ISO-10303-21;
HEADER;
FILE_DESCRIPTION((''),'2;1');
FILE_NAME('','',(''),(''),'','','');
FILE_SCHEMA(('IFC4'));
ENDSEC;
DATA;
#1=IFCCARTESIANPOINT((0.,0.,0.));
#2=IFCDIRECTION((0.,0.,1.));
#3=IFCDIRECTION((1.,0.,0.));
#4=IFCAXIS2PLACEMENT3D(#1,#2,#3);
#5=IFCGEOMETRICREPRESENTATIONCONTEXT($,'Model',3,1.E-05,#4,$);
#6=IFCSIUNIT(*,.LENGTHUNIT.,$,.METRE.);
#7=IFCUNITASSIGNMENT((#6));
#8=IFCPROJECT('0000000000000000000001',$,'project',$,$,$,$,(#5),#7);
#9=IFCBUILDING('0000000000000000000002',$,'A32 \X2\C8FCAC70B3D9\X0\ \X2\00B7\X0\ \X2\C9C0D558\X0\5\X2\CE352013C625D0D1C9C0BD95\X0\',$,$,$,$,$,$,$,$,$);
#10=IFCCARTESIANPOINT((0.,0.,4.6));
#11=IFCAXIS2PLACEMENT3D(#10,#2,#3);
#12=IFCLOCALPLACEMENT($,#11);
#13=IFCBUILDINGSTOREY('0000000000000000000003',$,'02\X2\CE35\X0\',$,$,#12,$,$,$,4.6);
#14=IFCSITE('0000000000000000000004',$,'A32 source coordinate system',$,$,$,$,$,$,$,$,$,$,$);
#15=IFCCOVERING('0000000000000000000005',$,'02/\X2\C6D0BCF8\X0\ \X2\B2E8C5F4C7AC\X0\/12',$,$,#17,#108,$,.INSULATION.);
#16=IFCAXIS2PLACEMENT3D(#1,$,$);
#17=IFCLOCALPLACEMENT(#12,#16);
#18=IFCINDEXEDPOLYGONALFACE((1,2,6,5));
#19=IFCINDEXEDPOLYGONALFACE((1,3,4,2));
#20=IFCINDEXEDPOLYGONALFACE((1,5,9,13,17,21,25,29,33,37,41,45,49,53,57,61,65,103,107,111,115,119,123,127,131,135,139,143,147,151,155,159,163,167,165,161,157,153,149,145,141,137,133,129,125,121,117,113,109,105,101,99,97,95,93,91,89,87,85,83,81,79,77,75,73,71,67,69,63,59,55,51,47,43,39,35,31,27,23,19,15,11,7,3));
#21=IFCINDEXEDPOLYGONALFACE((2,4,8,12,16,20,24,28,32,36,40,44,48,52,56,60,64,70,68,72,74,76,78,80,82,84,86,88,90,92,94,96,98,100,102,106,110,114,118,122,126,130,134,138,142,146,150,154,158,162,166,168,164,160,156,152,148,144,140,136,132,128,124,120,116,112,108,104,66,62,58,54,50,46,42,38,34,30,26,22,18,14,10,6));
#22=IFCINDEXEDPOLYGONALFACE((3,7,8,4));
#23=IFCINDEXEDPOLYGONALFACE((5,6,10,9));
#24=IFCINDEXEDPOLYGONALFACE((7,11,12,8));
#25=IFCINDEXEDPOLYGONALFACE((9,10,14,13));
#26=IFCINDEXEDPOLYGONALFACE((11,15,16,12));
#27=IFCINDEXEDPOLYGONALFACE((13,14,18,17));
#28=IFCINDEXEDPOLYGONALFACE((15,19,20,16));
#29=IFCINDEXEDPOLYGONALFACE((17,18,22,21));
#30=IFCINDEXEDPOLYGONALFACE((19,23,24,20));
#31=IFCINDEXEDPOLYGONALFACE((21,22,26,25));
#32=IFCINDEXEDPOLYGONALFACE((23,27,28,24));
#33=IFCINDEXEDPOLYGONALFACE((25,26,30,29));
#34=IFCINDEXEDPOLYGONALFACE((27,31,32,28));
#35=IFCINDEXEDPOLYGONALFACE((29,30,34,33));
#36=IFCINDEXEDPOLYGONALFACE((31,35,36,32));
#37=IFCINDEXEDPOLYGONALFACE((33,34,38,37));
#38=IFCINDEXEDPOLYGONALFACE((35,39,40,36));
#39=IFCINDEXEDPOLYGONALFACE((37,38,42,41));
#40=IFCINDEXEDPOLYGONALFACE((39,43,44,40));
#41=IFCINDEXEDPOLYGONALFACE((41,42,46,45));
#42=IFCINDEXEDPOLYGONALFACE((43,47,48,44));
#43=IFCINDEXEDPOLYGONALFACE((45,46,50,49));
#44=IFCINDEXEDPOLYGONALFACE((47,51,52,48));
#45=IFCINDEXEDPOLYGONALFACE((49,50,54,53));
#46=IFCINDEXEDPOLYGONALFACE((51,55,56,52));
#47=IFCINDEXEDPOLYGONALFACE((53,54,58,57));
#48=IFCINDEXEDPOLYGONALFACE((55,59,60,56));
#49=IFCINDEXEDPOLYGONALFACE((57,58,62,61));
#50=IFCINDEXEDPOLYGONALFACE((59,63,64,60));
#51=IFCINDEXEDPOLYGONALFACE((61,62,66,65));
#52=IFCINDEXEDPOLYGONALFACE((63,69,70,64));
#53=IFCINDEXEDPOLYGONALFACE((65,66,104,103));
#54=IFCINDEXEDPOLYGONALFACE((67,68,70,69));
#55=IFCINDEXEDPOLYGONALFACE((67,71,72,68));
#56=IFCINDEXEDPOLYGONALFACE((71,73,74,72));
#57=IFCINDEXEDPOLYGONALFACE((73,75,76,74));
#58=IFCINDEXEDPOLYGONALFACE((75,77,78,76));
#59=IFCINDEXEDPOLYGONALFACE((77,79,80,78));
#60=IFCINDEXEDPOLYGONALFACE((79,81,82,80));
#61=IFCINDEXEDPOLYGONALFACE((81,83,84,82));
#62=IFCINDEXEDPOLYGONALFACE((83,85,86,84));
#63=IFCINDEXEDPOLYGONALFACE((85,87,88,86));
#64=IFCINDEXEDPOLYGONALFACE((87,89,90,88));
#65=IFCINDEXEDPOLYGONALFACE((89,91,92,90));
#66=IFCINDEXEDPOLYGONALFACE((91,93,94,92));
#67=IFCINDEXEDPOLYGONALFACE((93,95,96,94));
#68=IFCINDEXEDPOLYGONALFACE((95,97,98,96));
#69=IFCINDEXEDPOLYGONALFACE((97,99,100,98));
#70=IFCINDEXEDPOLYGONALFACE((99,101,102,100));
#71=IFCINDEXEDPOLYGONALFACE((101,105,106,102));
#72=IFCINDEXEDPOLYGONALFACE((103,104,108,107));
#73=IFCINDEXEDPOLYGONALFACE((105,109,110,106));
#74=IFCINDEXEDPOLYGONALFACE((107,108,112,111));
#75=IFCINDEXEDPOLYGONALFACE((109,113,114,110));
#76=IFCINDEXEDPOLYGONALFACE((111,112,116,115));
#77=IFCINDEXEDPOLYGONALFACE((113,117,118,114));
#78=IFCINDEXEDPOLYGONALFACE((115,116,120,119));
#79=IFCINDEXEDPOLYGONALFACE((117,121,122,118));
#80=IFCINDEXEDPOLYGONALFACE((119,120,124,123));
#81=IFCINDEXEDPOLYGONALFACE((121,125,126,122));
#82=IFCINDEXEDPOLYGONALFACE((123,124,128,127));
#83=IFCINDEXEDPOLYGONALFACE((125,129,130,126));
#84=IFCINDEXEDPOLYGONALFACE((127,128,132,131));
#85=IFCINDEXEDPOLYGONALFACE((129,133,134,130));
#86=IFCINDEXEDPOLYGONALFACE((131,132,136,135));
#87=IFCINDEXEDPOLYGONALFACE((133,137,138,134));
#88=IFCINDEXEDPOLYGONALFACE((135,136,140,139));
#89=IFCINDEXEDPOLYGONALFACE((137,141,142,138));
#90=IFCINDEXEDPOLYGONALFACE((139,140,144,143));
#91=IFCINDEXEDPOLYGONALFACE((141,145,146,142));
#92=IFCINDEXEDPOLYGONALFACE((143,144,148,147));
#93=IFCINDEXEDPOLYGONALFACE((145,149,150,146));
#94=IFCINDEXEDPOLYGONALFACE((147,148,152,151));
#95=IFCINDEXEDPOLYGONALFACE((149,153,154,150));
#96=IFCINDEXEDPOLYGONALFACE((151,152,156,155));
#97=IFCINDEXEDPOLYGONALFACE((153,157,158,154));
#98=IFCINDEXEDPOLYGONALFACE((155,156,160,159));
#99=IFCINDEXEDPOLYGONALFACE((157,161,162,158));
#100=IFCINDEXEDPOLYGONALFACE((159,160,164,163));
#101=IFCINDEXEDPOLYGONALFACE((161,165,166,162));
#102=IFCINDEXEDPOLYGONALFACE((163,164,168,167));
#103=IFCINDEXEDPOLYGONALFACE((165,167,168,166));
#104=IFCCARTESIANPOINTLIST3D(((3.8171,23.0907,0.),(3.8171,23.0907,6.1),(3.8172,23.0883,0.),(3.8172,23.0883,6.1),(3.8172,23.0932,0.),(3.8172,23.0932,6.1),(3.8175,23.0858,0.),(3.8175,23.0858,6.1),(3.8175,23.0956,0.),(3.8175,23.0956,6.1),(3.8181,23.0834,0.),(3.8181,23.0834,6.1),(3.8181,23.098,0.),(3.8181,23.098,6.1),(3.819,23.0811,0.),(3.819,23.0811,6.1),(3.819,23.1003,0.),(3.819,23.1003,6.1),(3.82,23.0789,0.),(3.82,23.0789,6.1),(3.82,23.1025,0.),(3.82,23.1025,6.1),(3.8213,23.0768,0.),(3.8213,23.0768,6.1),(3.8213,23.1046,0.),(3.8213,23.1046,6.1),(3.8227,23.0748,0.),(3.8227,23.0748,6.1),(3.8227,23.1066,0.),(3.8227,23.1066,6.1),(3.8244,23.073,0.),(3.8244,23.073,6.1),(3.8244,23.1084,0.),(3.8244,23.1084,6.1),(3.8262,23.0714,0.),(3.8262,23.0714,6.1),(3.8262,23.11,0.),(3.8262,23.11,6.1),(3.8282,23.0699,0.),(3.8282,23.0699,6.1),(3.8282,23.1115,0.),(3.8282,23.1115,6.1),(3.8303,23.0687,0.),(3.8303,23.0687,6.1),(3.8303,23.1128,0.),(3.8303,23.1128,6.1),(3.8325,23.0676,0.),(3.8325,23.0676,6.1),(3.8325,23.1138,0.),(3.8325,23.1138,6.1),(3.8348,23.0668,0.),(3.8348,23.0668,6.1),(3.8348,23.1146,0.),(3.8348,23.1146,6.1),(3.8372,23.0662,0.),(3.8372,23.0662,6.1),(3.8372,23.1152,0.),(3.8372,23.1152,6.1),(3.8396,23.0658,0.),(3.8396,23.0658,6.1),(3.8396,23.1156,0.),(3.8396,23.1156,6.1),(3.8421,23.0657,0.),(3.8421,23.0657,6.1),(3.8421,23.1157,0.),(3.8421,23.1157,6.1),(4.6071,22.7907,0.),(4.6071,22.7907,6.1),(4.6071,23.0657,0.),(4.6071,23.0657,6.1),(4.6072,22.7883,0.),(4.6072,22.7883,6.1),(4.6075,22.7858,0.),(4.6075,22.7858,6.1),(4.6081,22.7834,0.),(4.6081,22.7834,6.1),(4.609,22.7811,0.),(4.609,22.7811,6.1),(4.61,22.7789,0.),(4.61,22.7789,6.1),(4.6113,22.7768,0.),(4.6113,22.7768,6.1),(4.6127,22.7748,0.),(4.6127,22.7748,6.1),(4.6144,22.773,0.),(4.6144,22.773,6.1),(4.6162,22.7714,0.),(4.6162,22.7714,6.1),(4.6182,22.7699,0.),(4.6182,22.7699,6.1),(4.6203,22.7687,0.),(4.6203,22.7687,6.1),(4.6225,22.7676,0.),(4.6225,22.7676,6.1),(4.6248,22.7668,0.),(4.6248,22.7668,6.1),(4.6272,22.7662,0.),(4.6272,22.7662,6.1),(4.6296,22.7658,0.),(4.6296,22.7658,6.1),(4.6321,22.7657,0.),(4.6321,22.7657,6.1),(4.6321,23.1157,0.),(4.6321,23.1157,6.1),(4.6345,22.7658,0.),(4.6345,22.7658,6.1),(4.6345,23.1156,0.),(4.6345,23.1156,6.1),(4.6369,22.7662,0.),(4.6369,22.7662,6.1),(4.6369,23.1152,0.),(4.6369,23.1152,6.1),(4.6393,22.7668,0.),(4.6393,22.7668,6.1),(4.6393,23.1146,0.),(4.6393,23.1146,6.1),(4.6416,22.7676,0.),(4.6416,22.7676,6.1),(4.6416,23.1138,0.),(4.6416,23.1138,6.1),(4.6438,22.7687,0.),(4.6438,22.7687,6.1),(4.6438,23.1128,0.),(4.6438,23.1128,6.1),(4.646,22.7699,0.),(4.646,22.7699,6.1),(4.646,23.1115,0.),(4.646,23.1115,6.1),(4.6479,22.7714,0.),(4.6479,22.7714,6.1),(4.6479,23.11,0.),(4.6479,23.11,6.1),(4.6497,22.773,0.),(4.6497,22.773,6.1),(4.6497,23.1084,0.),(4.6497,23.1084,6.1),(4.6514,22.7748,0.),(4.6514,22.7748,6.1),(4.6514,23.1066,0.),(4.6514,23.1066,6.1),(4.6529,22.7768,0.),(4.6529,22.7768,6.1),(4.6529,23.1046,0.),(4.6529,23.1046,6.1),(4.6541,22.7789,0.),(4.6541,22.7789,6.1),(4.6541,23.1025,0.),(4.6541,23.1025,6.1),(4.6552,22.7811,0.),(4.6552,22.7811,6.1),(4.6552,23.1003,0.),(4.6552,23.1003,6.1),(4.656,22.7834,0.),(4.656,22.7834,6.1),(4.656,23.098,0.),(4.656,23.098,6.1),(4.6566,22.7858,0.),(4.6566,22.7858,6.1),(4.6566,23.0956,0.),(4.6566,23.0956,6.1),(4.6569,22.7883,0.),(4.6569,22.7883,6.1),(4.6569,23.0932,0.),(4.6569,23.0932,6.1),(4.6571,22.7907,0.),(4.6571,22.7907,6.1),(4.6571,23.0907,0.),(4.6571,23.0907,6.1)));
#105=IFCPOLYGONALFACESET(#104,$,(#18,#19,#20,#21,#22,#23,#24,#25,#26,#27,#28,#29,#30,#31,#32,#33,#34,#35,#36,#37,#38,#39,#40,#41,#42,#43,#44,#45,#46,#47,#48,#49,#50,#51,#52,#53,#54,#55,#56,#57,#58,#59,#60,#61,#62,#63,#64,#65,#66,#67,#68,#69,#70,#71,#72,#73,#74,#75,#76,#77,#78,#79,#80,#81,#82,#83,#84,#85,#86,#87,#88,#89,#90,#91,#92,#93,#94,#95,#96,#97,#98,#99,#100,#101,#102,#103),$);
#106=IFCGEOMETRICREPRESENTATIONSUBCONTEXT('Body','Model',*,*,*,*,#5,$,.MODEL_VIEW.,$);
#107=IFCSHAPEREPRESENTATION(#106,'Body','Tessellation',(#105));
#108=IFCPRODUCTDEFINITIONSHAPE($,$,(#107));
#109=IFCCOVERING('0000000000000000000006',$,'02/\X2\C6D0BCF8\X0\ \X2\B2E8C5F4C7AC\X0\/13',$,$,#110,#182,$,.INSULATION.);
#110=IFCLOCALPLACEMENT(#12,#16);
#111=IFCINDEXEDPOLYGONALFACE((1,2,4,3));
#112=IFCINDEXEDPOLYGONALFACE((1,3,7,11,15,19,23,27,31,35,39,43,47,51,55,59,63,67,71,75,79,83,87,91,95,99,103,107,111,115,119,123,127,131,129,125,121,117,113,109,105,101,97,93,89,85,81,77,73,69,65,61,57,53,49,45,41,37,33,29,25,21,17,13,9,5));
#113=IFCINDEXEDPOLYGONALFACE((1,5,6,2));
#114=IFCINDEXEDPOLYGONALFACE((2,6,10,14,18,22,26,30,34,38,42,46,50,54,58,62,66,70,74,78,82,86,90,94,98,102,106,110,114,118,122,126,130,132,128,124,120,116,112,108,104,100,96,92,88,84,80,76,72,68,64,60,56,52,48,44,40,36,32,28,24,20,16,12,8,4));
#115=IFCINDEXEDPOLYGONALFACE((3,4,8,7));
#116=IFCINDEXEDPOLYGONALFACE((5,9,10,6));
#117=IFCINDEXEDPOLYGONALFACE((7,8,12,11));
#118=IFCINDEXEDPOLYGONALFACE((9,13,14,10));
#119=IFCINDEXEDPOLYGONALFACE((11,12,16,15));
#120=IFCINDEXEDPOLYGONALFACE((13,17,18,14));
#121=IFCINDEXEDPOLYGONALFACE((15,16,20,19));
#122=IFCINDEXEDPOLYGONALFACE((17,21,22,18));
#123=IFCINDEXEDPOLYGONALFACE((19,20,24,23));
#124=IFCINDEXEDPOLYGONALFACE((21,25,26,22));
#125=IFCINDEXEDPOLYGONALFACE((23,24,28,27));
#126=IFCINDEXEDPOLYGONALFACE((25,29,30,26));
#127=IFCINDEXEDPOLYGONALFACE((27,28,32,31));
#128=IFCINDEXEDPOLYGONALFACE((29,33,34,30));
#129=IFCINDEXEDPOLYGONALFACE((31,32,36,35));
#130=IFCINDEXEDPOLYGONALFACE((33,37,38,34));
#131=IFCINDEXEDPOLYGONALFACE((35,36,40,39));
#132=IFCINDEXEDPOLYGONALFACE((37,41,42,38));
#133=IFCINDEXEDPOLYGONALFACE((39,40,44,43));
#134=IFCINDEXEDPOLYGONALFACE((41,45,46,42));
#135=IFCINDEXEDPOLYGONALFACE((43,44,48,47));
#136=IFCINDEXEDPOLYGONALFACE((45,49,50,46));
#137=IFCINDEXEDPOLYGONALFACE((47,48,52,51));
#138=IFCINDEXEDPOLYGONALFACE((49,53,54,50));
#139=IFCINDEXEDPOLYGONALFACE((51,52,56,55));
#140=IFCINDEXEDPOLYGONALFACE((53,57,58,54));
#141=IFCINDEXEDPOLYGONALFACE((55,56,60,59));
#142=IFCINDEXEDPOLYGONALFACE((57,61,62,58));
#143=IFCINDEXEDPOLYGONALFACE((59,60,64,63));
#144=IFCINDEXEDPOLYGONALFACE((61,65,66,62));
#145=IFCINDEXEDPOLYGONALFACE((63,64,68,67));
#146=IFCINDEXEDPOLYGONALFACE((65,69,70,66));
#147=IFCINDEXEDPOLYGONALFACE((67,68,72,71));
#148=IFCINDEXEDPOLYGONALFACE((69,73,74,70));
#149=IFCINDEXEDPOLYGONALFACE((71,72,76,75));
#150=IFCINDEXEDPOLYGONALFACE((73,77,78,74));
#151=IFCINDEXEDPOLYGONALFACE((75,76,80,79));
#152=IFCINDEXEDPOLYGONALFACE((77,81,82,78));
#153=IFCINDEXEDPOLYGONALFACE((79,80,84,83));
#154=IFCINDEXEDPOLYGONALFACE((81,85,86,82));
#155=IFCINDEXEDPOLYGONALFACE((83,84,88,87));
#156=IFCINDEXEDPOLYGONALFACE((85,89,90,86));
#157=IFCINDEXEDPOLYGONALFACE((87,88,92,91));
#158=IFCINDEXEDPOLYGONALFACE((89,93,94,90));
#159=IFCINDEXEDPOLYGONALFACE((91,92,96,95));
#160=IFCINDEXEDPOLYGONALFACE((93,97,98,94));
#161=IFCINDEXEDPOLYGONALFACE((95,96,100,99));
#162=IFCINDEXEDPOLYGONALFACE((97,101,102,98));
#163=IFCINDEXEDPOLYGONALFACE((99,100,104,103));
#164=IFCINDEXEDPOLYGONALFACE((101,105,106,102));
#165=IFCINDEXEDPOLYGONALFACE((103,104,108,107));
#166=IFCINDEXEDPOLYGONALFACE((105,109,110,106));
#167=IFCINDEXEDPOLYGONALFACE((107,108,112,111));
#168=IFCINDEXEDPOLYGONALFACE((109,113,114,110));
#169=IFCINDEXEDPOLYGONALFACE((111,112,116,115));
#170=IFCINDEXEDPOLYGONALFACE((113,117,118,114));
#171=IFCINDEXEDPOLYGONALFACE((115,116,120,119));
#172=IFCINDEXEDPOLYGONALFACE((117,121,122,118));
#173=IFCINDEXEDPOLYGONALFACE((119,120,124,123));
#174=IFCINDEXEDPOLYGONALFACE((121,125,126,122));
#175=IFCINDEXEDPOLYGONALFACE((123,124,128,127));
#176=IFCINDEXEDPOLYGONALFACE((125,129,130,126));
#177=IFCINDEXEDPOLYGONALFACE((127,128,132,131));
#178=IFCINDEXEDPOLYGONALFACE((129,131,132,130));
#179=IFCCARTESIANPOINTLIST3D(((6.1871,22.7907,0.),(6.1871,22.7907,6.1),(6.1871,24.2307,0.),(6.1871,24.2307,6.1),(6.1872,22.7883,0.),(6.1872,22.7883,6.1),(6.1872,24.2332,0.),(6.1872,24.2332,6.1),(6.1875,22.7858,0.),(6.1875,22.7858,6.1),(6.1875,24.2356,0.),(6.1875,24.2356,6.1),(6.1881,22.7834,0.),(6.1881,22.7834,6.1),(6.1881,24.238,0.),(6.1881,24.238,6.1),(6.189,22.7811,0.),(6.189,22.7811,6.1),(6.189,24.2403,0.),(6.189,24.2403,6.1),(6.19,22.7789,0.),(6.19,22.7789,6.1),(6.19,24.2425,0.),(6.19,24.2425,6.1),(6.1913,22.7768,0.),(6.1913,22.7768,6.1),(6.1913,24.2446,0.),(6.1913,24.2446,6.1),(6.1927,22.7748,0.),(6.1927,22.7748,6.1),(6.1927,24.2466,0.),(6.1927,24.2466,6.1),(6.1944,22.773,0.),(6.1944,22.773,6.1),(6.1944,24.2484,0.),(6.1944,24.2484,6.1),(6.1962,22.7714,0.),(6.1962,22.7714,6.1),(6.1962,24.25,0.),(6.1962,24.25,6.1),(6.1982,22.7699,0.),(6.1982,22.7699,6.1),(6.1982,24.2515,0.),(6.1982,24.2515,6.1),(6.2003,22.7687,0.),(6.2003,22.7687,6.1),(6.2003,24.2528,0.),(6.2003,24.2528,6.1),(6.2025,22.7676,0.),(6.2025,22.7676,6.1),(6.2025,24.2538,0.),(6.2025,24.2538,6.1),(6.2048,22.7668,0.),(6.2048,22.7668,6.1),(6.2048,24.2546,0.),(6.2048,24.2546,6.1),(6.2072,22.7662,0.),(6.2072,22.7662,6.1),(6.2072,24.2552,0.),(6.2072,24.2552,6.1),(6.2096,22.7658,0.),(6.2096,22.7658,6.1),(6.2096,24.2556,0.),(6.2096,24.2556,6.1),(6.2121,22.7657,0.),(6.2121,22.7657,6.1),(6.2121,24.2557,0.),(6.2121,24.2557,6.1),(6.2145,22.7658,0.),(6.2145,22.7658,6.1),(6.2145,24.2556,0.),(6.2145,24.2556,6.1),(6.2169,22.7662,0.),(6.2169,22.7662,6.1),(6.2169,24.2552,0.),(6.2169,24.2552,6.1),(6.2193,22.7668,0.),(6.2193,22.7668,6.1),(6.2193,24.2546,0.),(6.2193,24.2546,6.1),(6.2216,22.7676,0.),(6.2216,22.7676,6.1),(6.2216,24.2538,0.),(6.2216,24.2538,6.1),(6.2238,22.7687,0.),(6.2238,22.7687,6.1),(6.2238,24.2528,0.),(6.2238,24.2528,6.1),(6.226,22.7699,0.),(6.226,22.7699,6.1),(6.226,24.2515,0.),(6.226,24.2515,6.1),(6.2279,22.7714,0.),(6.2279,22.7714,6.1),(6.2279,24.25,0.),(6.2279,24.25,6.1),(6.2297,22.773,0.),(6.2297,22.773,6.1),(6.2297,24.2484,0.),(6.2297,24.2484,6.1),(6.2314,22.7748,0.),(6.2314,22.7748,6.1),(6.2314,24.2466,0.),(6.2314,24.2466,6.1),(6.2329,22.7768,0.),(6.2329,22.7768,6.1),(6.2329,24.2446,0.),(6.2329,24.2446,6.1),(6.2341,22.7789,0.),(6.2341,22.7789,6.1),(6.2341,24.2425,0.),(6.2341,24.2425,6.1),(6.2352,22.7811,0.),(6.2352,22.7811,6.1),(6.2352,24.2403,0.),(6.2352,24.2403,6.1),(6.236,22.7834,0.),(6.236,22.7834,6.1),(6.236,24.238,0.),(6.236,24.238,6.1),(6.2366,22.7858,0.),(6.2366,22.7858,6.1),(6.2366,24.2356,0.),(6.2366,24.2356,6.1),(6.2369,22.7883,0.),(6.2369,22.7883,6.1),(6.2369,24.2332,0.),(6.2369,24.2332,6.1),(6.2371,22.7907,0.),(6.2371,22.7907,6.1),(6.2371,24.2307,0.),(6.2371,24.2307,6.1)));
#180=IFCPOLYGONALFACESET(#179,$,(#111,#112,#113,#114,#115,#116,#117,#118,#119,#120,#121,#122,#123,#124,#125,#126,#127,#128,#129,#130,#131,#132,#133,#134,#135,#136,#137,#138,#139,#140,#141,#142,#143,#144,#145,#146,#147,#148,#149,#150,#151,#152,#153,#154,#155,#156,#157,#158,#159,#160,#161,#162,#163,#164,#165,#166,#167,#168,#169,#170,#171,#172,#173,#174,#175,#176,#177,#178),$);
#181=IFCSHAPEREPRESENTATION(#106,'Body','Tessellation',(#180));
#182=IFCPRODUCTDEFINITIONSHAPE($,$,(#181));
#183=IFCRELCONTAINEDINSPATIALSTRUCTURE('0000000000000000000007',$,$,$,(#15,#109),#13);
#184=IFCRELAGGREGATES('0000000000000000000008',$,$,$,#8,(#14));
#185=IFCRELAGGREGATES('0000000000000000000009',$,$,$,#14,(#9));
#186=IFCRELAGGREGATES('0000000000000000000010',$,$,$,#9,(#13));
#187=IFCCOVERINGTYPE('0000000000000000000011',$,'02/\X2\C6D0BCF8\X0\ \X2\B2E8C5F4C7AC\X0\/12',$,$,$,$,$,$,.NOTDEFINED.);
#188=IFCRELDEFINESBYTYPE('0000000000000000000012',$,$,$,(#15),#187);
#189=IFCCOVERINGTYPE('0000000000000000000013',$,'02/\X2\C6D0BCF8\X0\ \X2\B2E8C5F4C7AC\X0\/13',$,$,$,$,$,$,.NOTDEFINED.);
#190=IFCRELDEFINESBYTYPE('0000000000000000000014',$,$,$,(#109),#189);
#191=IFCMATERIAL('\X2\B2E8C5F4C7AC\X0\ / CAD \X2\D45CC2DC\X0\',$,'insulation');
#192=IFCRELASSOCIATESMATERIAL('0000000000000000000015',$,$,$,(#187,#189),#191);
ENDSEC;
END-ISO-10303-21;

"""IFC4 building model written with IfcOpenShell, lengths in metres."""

from ifc_helpers import new_model, si_unit, frame, origin, origin_with_axes, place, context, subcontext, project, spatial, polyline, outline, extrude, source, transform, mapped, material, type_object, type_shapes, element, save


model = new_model("IFC4")

# Units and contexts
model_context = context("Model", 3, precision=1e-05, world=origin_with_axes())
body_context = subcontext(model_context, "Body", "Model", "MODEL_VIEW")
ifc_project = project(units=[si_unit("LENGTHUNIT", "METRE")], contexts=[model_context])

# Site, building, storey
site = spatial("IfcSite", under=ifc_project, Name="A32 source coordinate system")
building = spatial("IfcBuilding", under=site, Name="A32 주거동 · 지하5층–옥탑지붕")
storey_placement = place(None, frame((0.0, 0.0, 4.6), z_axis=(0.0, 0.0, 1.0), x_axis=(1.0, 0.0, 0.0)))
storey = spatial("IfcBuildingStorey", under=building, at=storey_placement, Name="02층", Elevation=4.6)

# Coverings
ifc_material = material(Name="단열재 / CAD 표시", Category="insulation")
covering_type_1 = type_object("IfcCoveringType", Name="02/원본 단열재/12", PredefinedType="NOTDEFINED", material=ifc_material)
shared_shape_1 = source(origin(), body_context, "Body", "SweptSolid", [
    extrude(outline(polyline([(3.8303, 23.0687), (3.8282, 23.0699), (3.8262, 23.0714), (3.8244, 23.073), (3.8227, 23.0748), (3.8213, 23.0768), (3.82, 23.0789), (3.819, 23.0811), (3.8181, 23.0834), (3.8175, 23.0858), (3.8172, 23.0883), (3.8171, 23.0907), (3.8172, 23.0932), (3.8175, 23.0956), (3.8181, 23.098), (3.819, 23.1003), (3.82, 23.1025), (3.8213, 23.1046), (3.8227, 23.1066), (3.8244, 23.1084), (3.8262, 23.11), (3.8282, 23.1115), (3.8303, 23.1128), (3.8325, 23.1138), (3.8348, 23.1146), (3.8372, 23.1152), (3.8396, 23.1156), (3.8421, 23.1157), (4.6321, 23.1157), (4.6345, 23.1156), (4.6369, 23.1152), (4.6393, 23.1146), (4.6416, 23.1138), (4.6438, 23.1128), (4.646, 23.1115), (4.6479, 23.11), (4.6497, 23.1084), (4.6514, 23.1066), (4.6529, 23.1046), (4.6541, 23.1025), (4.6552, 23.1003), (4.656, 23.098), (4.6566, 23.0956), (4.6569, 23.0932), (4.6571, 23.0907), (4.6571, 22.7907), (4.6569, 22.7883), (4.6566, 22.7858), (4.656, 22.7834), (4.6552, 22.7811), (4.6541, 22.7789), (4.6529, 22.7768), (4.6514, 22.7748), (4.6497, 22.773), (4.6479, 22.7714), (4.646, 22.7699), (4.6438, 22.7687), (4.6416, 22.7676), (4.6393, 22.7668), (4.6369, 22.7662), (4.6345, 22.7658), (4.6321, 22.7657), (4.6296, 22.7658), (4.6272, 22.7662), (4.6248, 22.7668), (4.6225, 22.7676), (4.6203, 22.7687), (4.6182, 22.7699), (4.6162, 22.7714), (4.6144, 22.773), (4.6127, 22.7748), (4.6113, 22.7768), (4.61, 22.7789), (4.609, 22.7811), (4.6081, 22.7834), (4.6075, 22.7858), (4.6072, 22.7883), (4.6071, 22.7907), (4.6071, 23.0657), (3.8421, 23.0657), (3.8396, 23.0658), (3.8372, 23.0662), (3.8348, 23.0668), (3.8325, 23.0676), (3.8303, 23.0687)])), origin(), (0.0, 0.0, 1.0), 6.1),
])
type_shapes(covering_type_1, [shared_shape_1])
covering_1_placement = place(storey_placement, origin_with_axes())
element("IfcCovering", 1, at=covering_1_placement, inside=storey, type_object=covering_type_1, Name="02/원본 단열재/12", PredefinedType="INSULATION", context=body_context, shape_type="MappedRepresentation", body=[
    mapped(shared_shape_1, transform((0.0, 0.0, 0.0), scale=1.0)),
])
covering_type_2 = type_object("IfcCoveringType", Name="02/원본 단열재/13", PredefinedType="NOTDEFINED", material=ifc_material)
shared_shape_2 = source(origin(), body_context, "Body", "SweptSolid", [
    extrude(outline(polyline([(6.19, 24.2425), (6.1913, 24.2446), (6.1927, 24.2466), (6.1944, 24.2484), (6.1962, 24.25), (6.1982, 24.2515), (6.2003, 24.2528), (6.2025, 24.2538), (6.2048, 24.2546), (6.2072, 24.2552), (6.2096, 24.2556), (6.2121, 24.2557), (6.2145, 24.2556), (6.2169, 24.2552), (6.2193, 24.2546), (6.2216, 24.2538), (6.2238, 24.2528), (6.226, 24.2515), (6.2279, 24.25), (6.2297, 24.2484), (6.2314, 24.2466), (6.2329, 24.2446), (6.2341, 24.2425), (6.2352, 24.2403), (6.236, 24.238), (6.2366, 24.2356), (6.2369, 24.2332), (6.2371, 24.2307), (6.2371, 22.7907), (6.2369, 22.7883), (6.2366, 22.7858), (6.236, 22.7834), (6.2352, 22.7811), (6.2341, 22.7789), (6.2329, 22.7768), (6.2314, 22.7748), (6.2297, 22.773), (6.2279, 22.7714), (6.226, 22.7699), (6.2238, 22.7687), (6.2216, 22.7676), (6.2193, 22.7668), (6.2169, 22.7662), (6.2145, 22.7658), (6.2121, 22.7657), (6.2096, 22.7658), (6.2072, 22.7662), (6.2048, 22.7668), (6.2025, 22.7676), (6.2003, 22.7687), (6.1982, 22.7699), (6.1962, 22.7714), (6.1944, 22.773), (6.1927, 22.7748), (6.1913, 22.7768), (6.19, 22.7789), (6.189, 22.7811), (6.1881, 22.7834), (6.1875, 22.7858), (6.1872, 22.7883), (6.1871, 22.7907), (6.1871, 24.2307), (6.1872, 24.2332), (6.1875, 24.2356), (6.1881, 24.238), (6.189, 24.2403), (6.19, 24.2425)])), origin(), (0.0, 0.0, 1.0), 6.1),
])
type_shapes(covering_type_2, [shared_shape_2])
covering_2_placement = place(storey_placement, origin_with_axes())
element("IfcCovering", 2, at=covering_2_placement, inside=storey, type_object=covering_type_2, Name="02/원본 단열재/13", PredefinedType="INSULATION", context=body_context, shape_type="MappedRepresentation", body=[
    mapped(shared_shape_2, transform((0.0, 0.0, 0.0), scale=1.0)),
])

save(model, "model.ifc")
